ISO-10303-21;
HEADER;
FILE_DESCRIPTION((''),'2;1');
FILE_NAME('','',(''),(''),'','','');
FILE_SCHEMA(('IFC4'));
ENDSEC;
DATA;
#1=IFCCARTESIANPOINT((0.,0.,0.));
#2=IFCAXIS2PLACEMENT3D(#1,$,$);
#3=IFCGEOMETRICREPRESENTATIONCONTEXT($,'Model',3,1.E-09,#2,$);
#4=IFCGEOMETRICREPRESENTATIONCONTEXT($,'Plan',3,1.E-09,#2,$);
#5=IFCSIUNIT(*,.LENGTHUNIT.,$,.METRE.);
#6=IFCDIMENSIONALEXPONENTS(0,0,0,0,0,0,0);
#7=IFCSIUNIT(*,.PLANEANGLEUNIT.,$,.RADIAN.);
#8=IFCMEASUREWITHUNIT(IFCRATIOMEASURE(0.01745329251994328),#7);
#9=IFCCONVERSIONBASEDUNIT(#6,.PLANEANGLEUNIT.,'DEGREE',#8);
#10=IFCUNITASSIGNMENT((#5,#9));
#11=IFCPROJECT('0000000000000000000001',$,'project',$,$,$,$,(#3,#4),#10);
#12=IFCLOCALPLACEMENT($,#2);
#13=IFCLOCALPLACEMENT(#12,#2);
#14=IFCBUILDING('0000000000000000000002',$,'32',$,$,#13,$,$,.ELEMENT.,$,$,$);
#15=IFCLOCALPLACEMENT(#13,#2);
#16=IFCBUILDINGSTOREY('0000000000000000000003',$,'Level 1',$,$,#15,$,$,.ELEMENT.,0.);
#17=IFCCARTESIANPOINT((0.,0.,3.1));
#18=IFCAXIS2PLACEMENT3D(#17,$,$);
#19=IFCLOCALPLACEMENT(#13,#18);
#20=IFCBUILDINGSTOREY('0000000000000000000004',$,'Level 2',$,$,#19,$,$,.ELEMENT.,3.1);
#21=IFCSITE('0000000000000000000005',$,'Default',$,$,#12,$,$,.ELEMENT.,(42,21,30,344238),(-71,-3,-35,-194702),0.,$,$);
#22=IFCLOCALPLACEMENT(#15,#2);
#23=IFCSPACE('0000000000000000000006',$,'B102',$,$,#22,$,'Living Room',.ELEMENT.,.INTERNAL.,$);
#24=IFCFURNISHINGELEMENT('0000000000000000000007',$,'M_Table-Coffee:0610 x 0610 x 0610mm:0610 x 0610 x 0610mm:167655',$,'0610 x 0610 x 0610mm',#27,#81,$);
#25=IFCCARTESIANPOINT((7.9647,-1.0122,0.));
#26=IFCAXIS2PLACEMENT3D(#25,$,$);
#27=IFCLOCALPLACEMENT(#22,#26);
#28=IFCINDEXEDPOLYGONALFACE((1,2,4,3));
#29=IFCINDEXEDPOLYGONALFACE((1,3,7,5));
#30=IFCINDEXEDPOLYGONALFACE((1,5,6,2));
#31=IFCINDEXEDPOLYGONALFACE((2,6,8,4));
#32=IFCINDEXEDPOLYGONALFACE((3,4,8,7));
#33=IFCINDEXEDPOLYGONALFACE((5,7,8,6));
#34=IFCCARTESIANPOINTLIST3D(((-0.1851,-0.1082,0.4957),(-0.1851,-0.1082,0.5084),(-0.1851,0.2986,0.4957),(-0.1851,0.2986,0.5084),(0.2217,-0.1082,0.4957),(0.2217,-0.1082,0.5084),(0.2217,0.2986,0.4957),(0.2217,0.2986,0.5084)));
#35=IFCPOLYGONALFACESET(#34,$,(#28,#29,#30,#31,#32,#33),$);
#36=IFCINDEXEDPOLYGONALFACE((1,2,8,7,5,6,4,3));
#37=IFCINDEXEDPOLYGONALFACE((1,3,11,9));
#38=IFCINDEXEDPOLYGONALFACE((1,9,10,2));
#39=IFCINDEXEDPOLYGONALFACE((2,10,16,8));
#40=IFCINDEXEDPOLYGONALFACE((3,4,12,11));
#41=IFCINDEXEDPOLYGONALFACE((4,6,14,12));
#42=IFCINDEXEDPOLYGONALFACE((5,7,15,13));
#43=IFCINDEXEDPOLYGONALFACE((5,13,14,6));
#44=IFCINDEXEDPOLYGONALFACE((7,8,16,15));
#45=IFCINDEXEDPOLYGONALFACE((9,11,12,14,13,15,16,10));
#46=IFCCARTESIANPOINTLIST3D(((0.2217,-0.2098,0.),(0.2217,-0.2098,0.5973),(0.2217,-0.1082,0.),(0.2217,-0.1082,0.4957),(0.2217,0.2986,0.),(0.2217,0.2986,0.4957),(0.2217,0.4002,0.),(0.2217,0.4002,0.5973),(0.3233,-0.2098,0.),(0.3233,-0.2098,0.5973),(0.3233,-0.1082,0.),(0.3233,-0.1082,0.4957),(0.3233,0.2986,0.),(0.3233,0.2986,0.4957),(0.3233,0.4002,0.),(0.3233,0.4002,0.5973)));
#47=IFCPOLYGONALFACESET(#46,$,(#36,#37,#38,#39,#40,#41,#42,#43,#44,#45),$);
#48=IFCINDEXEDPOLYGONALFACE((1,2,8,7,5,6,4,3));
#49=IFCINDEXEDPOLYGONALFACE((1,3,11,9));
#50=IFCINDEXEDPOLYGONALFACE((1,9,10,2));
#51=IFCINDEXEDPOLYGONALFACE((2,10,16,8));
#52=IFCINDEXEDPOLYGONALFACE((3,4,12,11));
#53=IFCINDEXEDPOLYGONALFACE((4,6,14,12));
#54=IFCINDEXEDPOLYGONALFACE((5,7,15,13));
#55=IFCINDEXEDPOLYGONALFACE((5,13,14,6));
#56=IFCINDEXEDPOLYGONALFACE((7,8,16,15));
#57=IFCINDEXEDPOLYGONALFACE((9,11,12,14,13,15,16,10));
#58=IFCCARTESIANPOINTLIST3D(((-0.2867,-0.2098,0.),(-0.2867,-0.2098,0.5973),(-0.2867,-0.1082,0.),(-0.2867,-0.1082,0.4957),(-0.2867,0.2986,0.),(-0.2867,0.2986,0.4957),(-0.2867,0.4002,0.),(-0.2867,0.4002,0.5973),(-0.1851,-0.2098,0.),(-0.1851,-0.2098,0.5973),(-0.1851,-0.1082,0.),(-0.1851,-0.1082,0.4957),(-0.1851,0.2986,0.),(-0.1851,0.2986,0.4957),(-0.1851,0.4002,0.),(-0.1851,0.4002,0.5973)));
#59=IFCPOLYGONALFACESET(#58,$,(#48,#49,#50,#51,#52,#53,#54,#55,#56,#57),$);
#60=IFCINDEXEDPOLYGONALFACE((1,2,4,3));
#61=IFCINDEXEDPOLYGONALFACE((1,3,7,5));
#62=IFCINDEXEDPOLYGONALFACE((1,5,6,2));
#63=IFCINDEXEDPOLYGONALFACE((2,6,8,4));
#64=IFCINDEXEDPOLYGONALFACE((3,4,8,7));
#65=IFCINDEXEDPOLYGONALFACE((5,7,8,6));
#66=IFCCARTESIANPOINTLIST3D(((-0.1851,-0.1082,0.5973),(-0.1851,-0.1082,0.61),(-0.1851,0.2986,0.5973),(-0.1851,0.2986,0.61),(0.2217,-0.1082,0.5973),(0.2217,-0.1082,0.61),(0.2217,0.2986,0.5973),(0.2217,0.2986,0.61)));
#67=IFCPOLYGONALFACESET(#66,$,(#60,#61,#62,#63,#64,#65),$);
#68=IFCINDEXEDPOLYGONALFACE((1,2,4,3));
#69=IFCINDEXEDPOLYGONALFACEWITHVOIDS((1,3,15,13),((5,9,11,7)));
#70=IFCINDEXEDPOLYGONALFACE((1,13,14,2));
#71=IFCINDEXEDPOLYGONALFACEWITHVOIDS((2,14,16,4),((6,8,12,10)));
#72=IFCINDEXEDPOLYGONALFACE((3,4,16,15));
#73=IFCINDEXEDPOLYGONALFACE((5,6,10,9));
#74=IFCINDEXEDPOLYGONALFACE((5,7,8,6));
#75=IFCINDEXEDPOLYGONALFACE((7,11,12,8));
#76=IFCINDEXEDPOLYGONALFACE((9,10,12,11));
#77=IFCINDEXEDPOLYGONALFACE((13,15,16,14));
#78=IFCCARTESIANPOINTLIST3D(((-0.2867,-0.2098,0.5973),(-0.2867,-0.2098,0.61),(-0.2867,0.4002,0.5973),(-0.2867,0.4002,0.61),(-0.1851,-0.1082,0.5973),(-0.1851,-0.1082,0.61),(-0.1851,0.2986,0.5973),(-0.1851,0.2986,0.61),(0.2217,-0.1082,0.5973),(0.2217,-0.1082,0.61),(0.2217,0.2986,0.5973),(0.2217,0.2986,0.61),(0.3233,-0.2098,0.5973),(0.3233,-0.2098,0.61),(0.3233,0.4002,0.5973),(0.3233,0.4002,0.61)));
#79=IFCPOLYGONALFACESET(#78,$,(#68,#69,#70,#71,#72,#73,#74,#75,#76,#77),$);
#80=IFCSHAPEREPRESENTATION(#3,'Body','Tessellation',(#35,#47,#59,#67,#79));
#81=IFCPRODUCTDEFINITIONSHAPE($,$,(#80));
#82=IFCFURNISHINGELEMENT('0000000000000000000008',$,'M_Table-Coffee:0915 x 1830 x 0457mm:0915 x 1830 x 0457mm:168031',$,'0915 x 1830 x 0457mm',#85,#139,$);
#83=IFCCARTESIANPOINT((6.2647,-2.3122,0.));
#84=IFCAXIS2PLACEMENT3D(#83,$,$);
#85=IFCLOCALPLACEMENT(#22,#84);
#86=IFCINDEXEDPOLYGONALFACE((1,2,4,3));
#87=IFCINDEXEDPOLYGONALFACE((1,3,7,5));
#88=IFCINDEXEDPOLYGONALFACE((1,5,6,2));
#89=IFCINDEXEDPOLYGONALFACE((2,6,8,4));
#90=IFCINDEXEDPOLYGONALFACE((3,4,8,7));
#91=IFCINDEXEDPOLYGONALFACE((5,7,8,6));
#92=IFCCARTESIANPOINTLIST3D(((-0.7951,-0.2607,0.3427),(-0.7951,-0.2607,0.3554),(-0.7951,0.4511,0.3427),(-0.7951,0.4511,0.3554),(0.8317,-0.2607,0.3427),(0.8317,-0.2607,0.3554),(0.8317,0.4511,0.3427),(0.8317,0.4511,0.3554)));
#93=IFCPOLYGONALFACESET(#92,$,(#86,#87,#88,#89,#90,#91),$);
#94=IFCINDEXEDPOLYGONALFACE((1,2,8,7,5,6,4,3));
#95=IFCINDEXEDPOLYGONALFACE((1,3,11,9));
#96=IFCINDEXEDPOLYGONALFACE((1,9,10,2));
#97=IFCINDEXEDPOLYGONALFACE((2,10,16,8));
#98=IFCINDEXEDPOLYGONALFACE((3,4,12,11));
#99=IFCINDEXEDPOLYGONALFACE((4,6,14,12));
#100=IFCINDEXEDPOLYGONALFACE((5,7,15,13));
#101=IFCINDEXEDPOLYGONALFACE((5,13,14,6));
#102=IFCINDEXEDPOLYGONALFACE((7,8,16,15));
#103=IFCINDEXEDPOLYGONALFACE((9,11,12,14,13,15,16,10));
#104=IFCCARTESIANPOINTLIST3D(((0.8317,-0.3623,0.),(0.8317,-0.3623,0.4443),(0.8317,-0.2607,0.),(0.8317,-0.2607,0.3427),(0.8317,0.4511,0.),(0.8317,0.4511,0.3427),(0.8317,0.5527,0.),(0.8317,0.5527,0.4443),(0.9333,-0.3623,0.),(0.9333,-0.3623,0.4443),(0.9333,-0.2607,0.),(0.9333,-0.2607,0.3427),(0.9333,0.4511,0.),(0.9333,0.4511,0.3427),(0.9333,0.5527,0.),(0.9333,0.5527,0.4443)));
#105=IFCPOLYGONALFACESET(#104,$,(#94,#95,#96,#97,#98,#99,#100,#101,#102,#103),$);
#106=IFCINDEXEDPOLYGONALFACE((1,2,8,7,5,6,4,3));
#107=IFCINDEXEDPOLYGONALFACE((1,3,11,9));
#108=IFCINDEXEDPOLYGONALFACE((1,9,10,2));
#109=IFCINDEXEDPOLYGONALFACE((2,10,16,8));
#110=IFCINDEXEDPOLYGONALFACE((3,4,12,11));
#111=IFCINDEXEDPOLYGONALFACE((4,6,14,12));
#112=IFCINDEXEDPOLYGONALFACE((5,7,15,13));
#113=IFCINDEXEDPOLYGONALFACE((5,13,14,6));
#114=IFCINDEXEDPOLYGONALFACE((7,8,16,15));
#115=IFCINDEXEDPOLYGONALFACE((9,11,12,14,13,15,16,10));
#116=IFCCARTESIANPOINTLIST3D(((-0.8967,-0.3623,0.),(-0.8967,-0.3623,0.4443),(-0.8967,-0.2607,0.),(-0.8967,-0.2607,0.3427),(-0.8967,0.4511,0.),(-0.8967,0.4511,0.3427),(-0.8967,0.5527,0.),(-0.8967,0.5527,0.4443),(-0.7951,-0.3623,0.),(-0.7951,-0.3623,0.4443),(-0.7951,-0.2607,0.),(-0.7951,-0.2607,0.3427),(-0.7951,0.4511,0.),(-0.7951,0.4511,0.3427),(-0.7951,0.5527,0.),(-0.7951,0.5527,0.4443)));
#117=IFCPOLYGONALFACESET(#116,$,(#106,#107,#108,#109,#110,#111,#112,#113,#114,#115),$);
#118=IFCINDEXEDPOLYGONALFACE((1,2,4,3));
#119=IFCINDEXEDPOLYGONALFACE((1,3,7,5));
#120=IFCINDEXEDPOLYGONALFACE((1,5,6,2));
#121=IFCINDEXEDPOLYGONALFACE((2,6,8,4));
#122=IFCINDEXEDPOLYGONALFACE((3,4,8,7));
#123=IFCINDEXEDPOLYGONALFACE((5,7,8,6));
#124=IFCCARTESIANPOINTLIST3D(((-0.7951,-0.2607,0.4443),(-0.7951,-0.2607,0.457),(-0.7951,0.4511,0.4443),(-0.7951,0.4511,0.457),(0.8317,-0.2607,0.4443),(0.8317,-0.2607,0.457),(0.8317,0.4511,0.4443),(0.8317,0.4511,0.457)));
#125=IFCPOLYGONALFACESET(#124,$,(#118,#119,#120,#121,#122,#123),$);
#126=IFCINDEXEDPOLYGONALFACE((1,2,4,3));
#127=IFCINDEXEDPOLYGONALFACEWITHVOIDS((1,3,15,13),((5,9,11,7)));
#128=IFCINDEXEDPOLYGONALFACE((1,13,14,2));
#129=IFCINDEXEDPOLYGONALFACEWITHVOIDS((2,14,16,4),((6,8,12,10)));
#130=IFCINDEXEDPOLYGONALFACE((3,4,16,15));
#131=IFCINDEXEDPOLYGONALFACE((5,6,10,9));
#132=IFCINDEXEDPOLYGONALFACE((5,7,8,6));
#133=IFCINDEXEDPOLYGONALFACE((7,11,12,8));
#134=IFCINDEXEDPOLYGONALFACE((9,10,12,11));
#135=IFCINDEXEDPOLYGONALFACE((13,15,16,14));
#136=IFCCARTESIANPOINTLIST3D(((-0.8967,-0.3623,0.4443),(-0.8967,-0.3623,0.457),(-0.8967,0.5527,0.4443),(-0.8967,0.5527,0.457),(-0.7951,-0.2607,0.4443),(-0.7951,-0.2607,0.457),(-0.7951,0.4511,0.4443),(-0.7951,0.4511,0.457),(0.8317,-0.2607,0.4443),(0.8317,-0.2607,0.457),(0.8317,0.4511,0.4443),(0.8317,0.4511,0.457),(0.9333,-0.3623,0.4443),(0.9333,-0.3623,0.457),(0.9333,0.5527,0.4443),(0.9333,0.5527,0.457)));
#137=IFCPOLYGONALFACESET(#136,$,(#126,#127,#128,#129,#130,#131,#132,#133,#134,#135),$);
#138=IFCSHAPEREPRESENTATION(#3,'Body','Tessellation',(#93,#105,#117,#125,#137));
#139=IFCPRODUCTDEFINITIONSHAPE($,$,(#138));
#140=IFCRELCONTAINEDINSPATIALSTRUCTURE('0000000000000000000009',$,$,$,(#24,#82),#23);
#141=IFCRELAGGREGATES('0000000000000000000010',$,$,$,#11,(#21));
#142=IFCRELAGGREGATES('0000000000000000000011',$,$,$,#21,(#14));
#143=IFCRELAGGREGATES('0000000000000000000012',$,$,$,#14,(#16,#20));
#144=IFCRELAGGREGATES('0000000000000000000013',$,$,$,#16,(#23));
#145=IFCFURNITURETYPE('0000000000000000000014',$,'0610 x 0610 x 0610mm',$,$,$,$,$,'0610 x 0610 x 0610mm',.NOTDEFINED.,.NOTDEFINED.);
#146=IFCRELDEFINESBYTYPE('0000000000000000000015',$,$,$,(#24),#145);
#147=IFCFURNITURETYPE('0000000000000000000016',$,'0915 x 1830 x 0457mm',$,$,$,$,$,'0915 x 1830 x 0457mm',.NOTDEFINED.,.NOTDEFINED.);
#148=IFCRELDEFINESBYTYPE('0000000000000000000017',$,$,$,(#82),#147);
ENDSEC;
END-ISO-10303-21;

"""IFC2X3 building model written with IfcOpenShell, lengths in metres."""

from ifc_helpers import new_model, entity, si_unit, converted_unit, frame, origin, origin_2d_with_axis, place, context, project, spatial, polyline, rectangle, outline, extrude, source, transform, mapped, type_object, type_shapes, element, save


model = new_model("IFC2X3")

# Units and contexts
model_context = context("Model", 3, precision=1e-09, world=origin())
plan_context = context("Plan", 3, precision=1e-09, world=origin())
ifc_project = project(units=[si_unit("LENGTHUNIT", "METRE"), converted_unit("PLANEANGLEUNIT", "DEGREE", entity("IfcRatioMeasure", 0.01745329251994328), si_unit("PLANEANGLEUNIT", "RADIAN"), dimensions=[0, 0, 0, 0, 0, 0, 0])], contexts=[model_context, plan_context])

# Site, building, storey
site_placement = place(None, origin())
site = spatial("IfcSite", under=ifc_project, at=site_placement, Name="Default", CompositionType="ELEMENT", RefLatitude=(42, 21, 30, 344238), RefLongitude=(-71, -3, -35, -194702), RefElevation=0.0)
building_placement = place(site_placement, origin())
building = spatial("IfcBuilding", under=site, at=building_placement, Name="32", CompositionType="ELEMENT")
storey_1_placement = place(building_placement, origin())
storey_1 = spatial("IfcBuildingStorey", under=building, at=storey_1_placement, Name="Level 1", CompositionType="ELEMENT", Elevation=0.0)

# Shared definitions
storey_2_placement = place(building_placement, frame((0.0, 0.0, 3.1)))
storey_2 = spatial("IfcBuildingStorey", under=building, at=storey_2_placement, Name="Level 2", CompositionType="ELEMENT", Elevation=3.1)

# Shared definitions
space_1_placement = place(storey_1_placement, origin())
space_1 = spatial("IfcSpace", under=storey_1, at=space_1_placement, Name="B102", LongName="Living Room", CompositionType="ELEMENT", InteriorOrExteriorSpace="INTERNAL")

# Furnishing elements
furniture_type_1 = type_object("IfcFurnitureType", Name="0610 x 0610 x 0610mm", ElementType="0610 x 0610 x 0610mm", AssemblyPlace="NOTDEFINED")
shared_shape_1 = source(origin(), model_context, "Body", "SweptSolid", [
    extrude(rectangle(XDim=0.4068, YDim=0.4068, at=origin_2d_with_axis()), frame((0.0183, 0.0952, 0.4957), z_axis=(0.0, 0.0, 1.0), x_axis=(-1.0, 0.0, 0.0)), (0.0, 0.0, 1.0), 0.0127),
    extrude(outline(polyline([(-0.2732, -0.305), (0.324, -0.305), (0.324, 0.305), (-0.2732, 0.305), (-0.2732, 0.2034), (0.2225, 0.2034), (0.2225, -0.2034), (-0.2732, -0.2034), (-0.2732, -0.305)])), frame((0.2217, 0.0952, 0.2732), z_axis=(1.0, 0.0, 0.0), x_axis=(0.0, 0.0, 1.0)), (0.0, 0.0, 1.0), 0.1016),
    extrude(outline(polyline([(-0.305, -0.3241), (0.305, -0.3241), (0.305, 0.2733), (0.2034, 0.2733), (0.2034, -0.2224), (-0.2034, -0.2224), (-0.2034, 0.2733), (-0.305, 0.2733), (-0.305, -0.3241)])), frame((-0.2867, 0.0952, 0.2733), z_axis=(1.0, 0.0, 0.0), x_axis=(0.0, -1.0, 0.0)), (0.0, 0.0, 1.0), 0.1016),
    extrude(rectangle(XDim=0.4068, YDim=0.4068, at=origin_2d_with_axis()), frame((0.0183, 0.0952, 0.5973), z_axis=(0.0, 0.0, 1.0), x_axis=(-1.0, 0.0, 0.0)), (0.0, 0.0, 1.0), 0.0127),
    extrude(outline(polyline([(-0.305, -0.305), (0.305, -0.305), (0.305, 0.305), (-0.305, 0.305), (-0.305, -0.305)]), holes=[polyline([(-0.2034, -0.2034), (-0.2034, 0.2034), (0.2034, 0.2034), (0.2034, -0.2034), (-0.2034, -0.2034)])]), frame((0.0183, 0.0952, 0.5973), z_axis=(0.0, 0.0, 1.0), x_axis=(-1.0, 0.0, 0.0)), (0.0, 0.0, 1.0), 0.0127),
])
type_shapes(furniture_type_1, [shared_shape_1])
for number, where, name in (
    (1, (7.9647, -1.0122, 0.0), "M_Table-Coffee:0610 x 0610 x 0610mm:0610 x 0610 x 0610mm:167655"),
):
    element("IfcFurnishingElement", number, at=place(space_1_placement, frame(where)), inside=space_1, type_object=furniture_type_1, Name=name, ObjectType="0610 x 0610 x 0610mm", context=model_context, shape_type="MappedRepresentation", body=[
        mapped(shared_shape_1, transform((0.0, 0.0, 0.0), scale=1.0)),
    ])
furniture_type_2 = type_object("IfcFurnitureType", Name="0915 x 1830 x 0457mm", ElementType="0915 x 1830 x 0457mm", AssemblyPlace="NOTDEFINED")
shared_shape_2 = source(origin(), model_context, "Body", "SweptSolid", [
    extrude(rectangle(XDim=1.6268, YDim=0.7118, at=origin_2d_with_axis()), frame((0.0183, 0.0952, 0.3427), z_axis=(0.0, 0.0, 1.0), x_axis=(-1.0, 0.0, 0.0)), (0.0, 0.0, 1.0), 0.0127),
    extrude(outline(polyline([(-0.1967, -0.4575), (0.2475, -0.4575), (0.2475, 0.4575), (-0.1967, 0.4575), (-0.1967, 0.3559), (0.146, 0.3559), (0.146, -0.3559), (-0.1967, -0.3559), (-0.1967, -0.4575)])), frame((0.8317, 0.0952, 0.1967), z_axis=(1.0, 0.0, 0.0), x_axis=(0.0, 0.0, 1.0)), (0.0, 0.0, 1.0), 0.1016),
    extrude(outline(polyline([(-0.4575, -0.2476), (0.4575, -0.2476), (0.4575, 0.1968), (0.3559, 0.1968), (0.3559, -0.1459), (-0.3559, -0.1459), (-0.3559, 0.1968), (-0.4575, 0.1968), (-0.4575, -0.2476)])), frame((-0.8967, 0.0952, 0.1968), z_axis=(1.0, 0.0, 0.0), x_axis=(0.0, -1.0, 0.0)), (0.0, 0.0, 1.0), 0.1016),
    extrude(rectangle(XDim=1.6268, YDim=0.7118, at=origin_2d_with_axis()), frame((0.0183, 0.0952, 0.4443), z_axis=(0.0, 0.0, 1.0), x_axis=(-1.0, 0.0, 0.0)), (0.0, 0.0, 1.0), 0.0127),
    extrude(outline(polyline([(-0.915, -0.4575), (0.915, -0.4575), (0.915, 0.4575), (-0.915, 0.4575), (-0.915, -0.4575)]), holes=[polyline([(-0.8134, -0.3559), (-0.8134, 0.3559), (0.8134, 0.3559), (0.8134, -0.3559), (-0.8134, -0.3559)])]), frame((0.0183, 0.0952, 0.4443), z_axis=(0.0, 0.0, 1.0), x_axis=(-1.0, 0.0, 0.0)), (0.0, 0.0, 1.0), 0.0127),
])
type_shapes(furniture_type_2, [shared_shape_2])
furnishing_1_placement = place(space_1_placement, frame((6.2647, -2.3122, 0.0)))
element("IfcFurnishingElement", 2, at=furnishing_1_placement, inside=space_1, type_object=furniture_type_2, Name="M_Table-Coffee:0915 x 1830 x 0457mm:0915 x 1830 x 0457mm:168031", ObjectType="0915 x 1830 x 0457mm", context=model_context, shape_type="MappedRepresentation", body=[
    mapped(shared_shape_2, transform((0.0, 0.0, 0.0), scale=1.0)),
])

save(model, "model.ifc")
